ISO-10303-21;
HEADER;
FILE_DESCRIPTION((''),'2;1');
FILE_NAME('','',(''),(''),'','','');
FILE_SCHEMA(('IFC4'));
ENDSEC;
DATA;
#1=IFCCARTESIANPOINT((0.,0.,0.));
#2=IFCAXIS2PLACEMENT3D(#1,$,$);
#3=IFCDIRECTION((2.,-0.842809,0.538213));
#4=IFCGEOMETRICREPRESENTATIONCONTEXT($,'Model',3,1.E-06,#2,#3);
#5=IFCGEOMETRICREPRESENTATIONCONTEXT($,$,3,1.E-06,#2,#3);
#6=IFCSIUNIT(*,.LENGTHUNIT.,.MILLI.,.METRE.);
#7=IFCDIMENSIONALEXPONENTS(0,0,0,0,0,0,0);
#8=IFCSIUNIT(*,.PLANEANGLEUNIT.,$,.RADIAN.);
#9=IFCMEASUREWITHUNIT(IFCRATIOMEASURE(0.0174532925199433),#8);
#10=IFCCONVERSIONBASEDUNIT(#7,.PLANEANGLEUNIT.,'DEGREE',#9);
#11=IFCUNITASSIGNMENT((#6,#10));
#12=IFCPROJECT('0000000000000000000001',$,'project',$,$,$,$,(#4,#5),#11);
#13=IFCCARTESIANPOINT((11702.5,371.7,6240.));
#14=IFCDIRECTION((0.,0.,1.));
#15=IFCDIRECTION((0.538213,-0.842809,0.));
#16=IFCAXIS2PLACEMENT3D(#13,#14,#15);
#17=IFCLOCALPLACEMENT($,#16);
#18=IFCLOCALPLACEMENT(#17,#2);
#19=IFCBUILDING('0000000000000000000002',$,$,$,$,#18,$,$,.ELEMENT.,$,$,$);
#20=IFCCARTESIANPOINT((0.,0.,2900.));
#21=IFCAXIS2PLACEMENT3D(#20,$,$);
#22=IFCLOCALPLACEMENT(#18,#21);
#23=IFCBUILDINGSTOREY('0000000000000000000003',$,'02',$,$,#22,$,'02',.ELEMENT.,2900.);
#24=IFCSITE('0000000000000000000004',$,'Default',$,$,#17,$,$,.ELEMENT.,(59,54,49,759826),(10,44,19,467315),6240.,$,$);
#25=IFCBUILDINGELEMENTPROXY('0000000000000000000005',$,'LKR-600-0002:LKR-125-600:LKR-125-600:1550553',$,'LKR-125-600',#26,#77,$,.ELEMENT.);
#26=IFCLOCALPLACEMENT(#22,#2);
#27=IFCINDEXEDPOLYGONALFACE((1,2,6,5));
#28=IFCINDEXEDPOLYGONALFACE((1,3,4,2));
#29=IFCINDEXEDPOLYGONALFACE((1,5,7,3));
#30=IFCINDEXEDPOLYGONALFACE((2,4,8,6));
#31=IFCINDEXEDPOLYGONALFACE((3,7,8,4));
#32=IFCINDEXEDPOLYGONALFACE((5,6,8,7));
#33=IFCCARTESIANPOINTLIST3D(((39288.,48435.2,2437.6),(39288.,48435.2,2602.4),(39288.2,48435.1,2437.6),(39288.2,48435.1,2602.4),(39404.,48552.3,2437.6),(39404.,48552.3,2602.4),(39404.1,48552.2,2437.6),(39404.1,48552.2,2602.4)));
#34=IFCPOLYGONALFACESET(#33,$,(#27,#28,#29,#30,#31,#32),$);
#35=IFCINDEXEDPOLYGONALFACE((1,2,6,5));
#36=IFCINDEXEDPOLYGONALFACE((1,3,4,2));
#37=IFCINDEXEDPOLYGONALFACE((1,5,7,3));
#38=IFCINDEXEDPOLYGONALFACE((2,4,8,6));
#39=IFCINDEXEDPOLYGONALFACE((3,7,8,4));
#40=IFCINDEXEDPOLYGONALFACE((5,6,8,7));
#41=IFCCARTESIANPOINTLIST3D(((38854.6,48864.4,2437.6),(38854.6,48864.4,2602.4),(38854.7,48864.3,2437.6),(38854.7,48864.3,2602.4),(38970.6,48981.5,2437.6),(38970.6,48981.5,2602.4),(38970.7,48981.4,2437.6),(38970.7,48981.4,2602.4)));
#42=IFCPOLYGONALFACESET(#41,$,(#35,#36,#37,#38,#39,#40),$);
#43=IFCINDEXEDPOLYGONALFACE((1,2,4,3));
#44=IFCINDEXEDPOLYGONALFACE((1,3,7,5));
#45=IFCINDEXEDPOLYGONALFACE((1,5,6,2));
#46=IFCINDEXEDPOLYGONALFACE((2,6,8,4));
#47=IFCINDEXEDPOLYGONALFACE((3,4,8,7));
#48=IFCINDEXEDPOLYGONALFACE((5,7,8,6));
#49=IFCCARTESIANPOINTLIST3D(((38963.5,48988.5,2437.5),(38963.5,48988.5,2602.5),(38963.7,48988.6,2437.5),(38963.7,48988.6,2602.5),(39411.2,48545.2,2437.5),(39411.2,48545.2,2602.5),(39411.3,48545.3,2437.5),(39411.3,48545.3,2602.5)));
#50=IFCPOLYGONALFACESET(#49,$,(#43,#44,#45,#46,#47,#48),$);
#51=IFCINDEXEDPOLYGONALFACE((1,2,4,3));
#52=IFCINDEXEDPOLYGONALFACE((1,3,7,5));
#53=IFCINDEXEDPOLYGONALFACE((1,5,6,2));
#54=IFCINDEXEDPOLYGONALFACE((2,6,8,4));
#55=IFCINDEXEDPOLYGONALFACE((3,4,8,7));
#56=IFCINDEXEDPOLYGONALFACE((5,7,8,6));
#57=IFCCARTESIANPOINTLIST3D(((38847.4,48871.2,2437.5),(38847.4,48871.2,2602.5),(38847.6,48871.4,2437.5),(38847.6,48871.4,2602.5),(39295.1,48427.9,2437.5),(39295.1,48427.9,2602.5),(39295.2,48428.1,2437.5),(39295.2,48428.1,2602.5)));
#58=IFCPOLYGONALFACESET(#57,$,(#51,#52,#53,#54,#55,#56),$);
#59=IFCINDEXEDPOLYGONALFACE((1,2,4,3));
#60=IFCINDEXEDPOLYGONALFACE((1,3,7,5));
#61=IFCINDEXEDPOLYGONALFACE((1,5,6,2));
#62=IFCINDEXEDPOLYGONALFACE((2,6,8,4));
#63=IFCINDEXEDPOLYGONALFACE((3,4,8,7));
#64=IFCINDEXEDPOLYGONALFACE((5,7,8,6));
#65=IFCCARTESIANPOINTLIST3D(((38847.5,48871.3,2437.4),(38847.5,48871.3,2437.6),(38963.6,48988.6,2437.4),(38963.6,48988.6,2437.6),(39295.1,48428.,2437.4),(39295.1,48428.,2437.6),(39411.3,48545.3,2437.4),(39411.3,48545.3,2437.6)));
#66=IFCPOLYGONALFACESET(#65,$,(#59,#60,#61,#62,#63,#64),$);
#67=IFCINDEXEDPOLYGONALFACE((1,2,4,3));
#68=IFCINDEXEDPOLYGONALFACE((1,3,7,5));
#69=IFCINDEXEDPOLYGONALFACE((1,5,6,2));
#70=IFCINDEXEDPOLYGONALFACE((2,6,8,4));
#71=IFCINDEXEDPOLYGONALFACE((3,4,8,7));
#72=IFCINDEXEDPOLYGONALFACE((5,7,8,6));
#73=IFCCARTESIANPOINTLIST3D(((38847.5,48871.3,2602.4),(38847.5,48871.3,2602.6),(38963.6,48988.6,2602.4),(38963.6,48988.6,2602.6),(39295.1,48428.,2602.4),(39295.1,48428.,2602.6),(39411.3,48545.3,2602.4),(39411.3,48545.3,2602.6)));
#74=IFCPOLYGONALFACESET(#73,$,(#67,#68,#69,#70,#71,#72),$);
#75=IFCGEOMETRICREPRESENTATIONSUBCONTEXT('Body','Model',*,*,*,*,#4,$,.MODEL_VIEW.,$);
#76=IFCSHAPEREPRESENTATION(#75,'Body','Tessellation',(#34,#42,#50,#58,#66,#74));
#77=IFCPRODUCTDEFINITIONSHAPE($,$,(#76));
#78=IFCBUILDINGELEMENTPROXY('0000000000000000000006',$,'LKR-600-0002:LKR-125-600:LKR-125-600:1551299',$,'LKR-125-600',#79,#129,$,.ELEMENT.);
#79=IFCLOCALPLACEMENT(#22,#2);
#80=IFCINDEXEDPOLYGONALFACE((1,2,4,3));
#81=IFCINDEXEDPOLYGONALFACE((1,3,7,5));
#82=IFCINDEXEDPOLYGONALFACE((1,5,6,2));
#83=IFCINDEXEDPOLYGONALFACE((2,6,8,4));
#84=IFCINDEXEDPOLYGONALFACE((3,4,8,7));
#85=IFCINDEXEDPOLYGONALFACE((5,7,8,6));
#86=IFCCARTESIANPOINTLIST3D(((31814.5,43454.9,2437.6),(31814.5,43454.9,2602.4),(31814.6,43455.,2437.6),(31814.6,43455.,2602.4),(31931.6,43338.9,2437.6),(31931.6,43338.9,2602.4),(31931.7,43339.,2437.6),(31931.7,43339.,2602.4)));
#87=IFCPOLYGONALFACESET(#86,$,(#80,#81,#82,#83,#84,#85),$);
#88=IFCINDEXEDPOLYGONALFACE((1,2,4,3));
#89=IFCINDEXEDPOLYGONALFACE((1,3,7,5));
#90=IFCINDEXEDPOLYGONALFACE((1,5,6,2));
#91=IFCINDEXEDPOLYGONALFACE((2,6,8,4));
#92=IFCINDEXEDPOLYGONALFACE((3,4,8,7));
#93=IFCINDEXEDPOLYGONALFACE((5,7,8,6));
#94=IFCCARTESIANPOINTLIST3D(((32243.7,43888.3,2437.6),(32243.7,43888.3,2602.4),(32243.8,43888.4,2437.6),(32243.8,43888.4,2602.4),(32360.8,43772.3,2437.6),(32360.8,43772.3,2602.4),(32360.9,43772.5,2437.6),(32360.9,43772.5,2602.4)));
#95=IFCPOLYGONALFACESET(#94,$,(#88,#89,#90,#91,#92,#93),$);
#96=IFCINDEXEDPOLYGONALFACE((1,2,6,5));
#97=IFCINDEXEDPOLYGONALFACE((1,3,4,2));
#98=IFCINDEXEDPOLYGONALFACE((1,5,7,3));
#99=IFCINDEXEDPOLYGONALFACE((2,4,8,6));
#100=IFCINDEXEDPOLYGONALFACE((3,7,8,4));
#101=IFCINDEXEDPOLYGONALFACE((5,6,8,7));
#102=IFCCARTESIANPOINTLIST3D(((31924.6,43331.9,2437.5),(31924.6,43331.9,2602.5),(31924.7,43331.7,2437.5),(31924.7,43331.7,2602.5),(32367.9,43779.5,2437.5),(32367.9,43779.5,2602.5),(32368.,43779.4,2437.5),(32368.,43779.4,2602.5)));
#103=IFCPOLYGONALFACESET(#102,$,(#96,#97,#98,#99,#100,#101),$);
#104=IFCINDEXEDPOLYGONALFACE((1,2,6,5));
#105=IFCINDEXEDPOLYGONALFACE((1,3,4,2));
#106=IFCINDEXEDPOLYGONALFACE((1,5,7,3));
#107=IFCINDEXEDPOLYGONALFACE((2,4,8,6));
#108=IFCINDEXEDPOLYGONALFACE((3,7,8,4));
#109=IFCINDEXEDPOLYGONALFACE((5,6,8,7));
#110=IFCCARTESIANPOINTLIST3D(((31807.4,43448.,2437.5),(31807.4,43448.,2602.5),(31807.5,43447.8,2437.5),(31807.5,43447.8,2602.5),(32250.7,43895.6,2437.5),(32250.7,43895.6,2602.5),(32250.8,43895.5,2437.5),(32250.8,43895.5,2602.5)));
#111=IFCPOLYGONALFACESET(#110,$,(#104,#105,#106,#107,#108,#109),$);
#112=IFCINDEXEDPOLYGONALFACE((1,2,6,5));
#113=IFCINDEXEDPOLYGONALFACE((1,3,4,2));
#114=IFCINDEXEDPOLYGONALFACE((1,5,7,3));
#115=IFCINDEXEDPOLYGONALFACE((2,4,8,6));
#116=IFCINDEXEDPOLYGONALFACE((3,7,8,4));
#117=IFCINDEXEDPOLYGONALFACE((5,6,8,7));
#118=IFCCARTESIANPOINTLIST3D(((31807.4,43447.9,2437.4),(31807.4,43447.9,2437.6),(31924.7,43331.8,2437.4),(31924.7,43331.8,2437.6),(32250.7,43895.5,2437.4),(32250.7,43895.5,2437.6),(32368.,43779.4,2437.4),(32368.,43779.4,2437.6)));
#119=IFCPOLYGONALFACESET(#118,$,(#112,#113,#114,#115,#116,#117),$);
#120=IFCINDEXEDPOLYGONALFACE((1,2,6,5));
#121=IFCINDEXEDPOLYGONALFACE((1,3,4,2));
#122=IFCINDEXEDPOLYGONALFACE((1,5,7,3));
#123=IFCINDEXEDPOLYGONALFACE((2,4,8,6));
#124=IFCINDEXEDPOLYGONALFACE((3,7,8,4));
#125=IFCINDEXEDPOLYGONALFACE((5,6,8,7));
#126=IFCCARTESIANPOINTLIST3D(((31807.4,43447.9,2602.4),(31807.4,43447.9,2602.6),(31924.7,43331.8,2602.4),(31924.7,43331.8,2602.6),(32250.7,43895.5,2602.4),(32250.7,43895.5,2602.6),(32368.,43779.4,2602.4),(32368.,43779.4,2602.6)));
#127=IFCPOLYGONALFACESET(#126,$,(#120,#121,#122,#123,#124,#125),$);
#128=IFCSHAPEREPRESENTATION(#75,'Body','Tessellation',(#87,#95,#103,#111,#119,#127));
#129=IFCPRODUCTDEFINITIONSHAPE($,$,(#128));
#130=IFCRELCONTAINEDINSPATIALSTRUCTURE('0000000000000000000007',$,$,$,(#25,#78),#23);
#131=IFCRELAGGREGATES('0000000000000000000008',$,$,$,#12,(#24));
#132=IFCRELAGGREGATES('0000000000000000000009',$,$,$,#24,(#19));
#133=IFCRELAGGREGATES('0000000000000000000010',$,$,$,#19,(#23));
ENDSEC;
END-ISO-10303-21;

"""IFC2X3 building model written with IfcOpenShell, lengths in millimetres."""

from ifc_helpers import new_model, entity, si_unit, converted_unit, direction, frame, frame_2d, origin, place, context, subcontext, project, spatial, rectangle, extrude, source, transform, mapped, element, save


model = new_model("IFC2X3")

# Units and contexts
model_context = context("Model", 3, precision=1e-06, world=origin(), true_north=direction((2.0, -0.842809, 0.538213)))
context_of_model = context(None, 3, precision=1e-06, world=origin(), true_north=direction((2.0, -0.842809, 0.538213)))
body_context = subcontext(model_context, "Body", "Model", "MODEL_VIEW")
ifc_project = project(units=[si_unit("LENGTHUNIT", "METRE", prefix="MILLI"), converted_unit("PLANEANGLEUNIT", "DEGREE", entity("IfcRatioMeasure", 0.0174532925199433), si_unit("PLANEANGLEUNIT", "RADIAN"), dimensions=[0, 0, 0, 0, 0, 0, 0])], contexts=[model_context, context_of_model])

# Site, building, storey
site_placement = place(None, frame((11702.5, 371.7, 6240.0), z_axis=(0.0, 0.0, 1.0), x_axis=(0.538213, -0.842809, 0.0)))
site = spatial("IfcSite", under=ifc_project, at=site_placement, Name="Default", CompositionType="ELEMENT", RefLatitude=(59, 54, 49, 759826), RefLongitude=(10, 44, 19, 467315), RefElevation=6240.0)
building_placement = place(site_placement, origin())
building = spatial("IfcBuilding", under=site, at=building_placement, CompositionType="ELEMENT")
storey_placement = place(building_placement, frame((0.0, 0.0, 2900.0)))
storey = spatial("IfcBuildingStorey", under=building, at=storey_placement, Name="02", LongName="02", CompositionType="ELEMENT", Elevation=2900.0)

# Building element proxies
shared_shape_1 = source(origin(), body_context, "Body", "SweptSolid", [
    extrude(rectangle(XDim=0.2, YDim=164.8, at=frame_2d((0.0, 0.0), x_axis=(1.0, 0.0))), frame((305.0, 0.0, -82.4)), (0.0, 0.0, 1.0), 164.8),
    extrude(rectangle(XDim=0.2, YDim=164.8, at=frame_2d((0.0, 0.0), x_axis=(1.0, 0.0))), frame((-305.0, 0.0, -82.4)), (0.0, 0.0, 1.0), 164.8),
    extrude(rectangle(XDim=0.2, YDim=630.0, at=frame_2d((0.0, 0.0), x_axis=(1.0, 0.0))), frame((0.0, 82.5, -82.5), z_axis=(0.0, 0.0, 1.0), x_axis=(0.0, 1.0, 0.0)), (0.0, 0.0, 1.0), 165.0),
    extrude(rectangle(XDim=0.2, YDim=630.0, at=frame_2d((0.0, 0.0), x_axis=(1.0, 0.0))), frame((0.0, -82.5, -82.5), z_axis=(0.0, 0.0, 1.0), x_axis=(0.0, 1.0, 0.0)), (0.0, 0.0, 1.0), 165.0),
    extrude(rectangle(XDim=165.0, YDim=630.0, at=frame_2d((0.0, 0.0), x_axis=(1.0, 0.0))), frame((0.0, 0.0, -82.6), z_axis=(0.0, 0.0, 1.0), x_axis=(0.0, -1.0, 0.0)), (0.0, 0.0, 1.0), 0.2),
    extrude(rectangle(XDim=165.0, YDim=630.0, at=frame_2d((0.0, 0.0), x_axis=(1.0, 0.0))), frame((0.0, 0.0, 82.4), z_axis=(0.0, 0.0, 1.0), x_axis=(0.0, -1.0, 0.0)), (0.0, 0.0, 1.0), 0.2),
])
for number, where, z_axis, x_axis, name in (
    (1, (39129.4, 48708.3, 2520.0), (0.0, 0.0, 1.0), (0.710554, -0.703643, 0.0), "LKR-600-0002:LKR-125-600:LKR-125-600:1550553"),
    (2, (32087.7, 43613.7, 2520.0), (0.0, 0.0, 1.0), (-0.703643, -0.710554, 0.0), "LKR-600-0002:LKR-125-600:LKR-125-600:1551299"),
):
    element("IfcBuildingElementProxy", number, at=place(storey_placement, frame(where, z_axis=z_axis, x_axis=x_axis)), inside=storey, Name=name, ObjectType="LKR-125-600", CompositionType="ELEMENT", context=body_context, shape_type="MappedRepresentation", body=[
        mapped(shared_shape_1, transform((0.0, 0.0, 0.0), scale=1.0)),
    ])

save(model, "model.ifc")
